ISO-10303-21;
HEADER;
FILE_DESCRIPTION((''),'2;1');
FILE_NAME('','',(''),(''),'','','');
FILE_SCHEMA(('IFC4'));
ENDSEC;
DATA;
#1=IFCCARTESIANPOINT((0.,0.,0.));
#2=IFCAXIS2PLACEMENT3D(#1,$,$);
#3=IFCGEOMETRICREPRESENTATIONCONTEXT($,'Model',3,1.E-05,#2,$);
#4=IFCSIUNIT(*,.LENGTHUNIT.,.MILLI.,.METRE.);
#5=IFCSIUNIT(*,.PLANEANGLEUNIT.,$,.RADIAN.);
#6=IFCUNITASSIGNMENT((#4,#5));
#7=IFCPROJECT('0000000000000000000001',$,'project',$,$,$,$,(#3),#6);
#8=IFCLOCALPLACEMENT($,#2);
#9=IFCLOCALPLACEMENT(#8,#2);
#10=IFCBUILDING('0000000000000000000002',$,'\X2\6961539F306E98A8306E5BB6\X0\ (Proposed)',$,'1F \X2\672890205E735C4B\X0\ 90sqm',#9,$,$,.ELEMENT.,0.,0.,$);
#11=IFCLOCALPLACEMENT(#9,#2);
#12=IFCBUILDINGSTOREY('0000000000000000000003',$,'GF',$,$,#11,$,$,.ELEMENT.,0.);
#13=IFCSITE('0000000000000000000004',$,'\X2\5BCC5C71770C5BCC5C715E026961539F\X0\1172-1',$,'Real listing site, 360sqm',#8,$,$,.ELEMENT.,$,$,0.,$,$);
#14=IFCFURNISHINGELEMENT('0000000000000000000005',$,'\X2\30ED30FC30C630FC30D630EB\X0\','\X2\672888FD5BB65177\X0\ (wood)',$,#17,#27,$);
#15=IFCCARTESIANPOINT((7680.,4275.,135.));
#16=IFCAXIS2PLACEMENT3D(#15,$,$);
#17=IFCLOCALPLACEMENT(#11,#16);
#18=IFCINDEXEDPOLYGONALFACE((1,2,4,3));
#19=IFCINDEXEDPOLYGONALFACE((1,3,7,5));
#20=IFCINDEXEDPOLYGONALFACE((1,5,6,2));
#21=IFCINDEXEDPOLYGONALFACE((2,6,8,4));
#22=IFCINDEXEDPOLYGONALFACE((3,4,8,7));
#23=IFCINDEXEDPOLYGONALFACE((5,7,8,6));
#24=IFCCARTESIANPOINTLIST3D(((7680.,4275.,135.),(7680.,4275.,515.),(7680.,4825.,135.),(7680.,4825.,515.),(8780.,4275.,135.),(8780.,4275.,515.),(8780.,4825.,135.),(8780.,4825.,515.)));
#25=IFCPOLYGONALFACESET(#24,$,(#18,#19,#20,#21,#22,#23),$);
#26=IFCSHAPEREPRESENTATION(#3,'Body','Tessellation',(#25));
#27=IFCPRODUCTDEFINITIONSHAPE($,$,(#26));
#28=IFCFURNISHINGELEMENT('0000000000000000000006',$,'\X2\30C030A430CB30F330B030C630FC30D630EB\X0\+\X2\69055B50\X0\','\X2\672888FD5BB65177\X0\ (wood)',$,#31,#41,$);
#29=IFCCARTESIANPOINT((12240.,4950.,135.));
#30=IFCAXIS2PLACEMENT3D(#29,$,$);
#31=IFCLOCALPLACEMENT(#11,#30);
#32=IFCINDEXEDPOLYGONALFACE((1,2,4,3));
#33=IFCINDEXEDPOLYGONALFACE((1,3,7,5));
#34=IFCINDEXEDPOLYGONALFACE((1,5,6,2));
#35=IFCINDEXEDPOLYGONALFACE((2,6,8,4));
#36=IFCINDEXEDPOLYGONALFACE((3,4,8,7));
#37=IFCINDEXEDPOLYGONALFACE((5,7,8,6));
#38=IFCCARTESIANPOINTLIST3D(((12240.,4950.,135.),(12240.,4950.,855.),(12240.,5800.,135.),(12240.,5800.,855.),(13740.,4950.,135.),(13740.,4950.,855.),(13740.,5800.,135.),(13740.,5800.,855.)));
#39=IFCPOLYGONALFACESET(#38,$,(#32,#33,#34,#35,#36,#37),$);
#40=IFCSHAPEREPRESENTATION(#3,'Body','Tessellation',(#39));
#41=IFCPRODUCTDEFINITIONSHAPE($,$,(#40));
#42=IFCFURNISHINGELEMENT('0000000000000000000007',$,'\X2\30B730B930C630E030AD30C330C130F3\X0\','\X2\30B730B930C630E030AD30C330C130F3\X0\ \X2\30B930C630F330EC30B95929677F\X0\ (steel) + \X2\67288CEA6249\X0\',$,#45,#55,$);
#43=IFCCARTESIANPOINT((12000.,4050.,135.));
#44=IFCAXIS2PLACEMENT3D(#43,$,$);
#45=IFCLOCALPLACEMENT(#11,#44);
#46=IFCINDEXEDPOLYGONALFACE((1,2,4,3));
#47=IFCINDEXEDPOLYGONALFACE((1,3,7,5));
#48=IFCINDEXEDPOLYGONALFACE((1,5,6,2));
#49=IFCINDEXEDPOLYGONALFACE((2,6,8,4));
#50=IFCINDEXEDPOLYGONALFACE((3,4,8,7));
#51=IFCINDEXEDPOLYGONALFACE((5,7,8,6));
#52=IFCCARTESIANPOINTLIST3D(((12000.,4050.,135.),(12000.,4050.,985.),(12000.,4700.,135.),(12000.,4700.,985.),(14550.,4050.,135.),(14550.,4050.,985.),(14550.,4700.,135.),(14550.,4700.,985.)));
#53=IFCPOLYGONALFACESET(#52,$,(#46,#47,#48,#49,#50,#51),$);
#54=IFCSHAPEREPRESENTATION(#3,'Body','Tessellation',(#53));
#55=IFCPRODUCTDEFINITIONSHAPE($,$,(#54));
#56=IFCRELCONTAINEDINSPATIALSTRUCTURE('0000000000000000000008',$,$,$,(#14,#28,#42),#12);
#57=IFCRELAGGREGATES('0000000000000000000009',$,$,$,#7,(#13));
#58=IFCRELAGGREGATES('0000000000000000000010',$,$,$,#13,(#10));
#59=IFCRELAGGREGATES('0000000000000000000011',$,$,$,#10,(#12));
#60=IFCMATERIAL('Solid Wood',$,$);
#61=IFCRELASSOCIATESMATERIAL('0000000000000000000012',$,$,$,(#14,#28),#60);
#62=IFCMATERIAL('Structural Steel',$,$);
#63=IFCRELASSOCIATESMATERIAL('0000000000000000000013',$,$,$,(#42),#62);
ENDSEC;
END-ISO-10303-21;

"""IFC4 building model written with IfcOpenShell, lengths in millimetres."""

from ifc_helpers import new_model, si_unit, frame, frame_2d, origin, place, context, project, spatial, rectangle, extrude, material, element, save


model = new_model("IFC4")

# Units and contexts
model_context = context("Model", 3, precision=1e-05, world=origin())
ifc_project = project(units=[si_unit("LENGTHUNIT", "METRE", prefix="MILLI"), si_unit("PLANEANGLEUNIT", "RADIAN")], contexts=[model_context])

# Site, building, storey
site_placement = place(None, origin())
site = spatial("IfcSite", under=ifc_project, at=site_placement, Name="富山県富山市楡原1172-1", ObjectType="Real listing site, 360sqm", CompositionType="ELEMENT", RefElevation=0.0)
building_placement = place(site_placement, origin())
building = spatial("IfcBuilding", under=site, at=building_placement, Name="楡原の風の家 (Proposed)", ObjectType="1F 木造平屋 90sqm", CompositionType="ELEMENT", ElevationOfRefHeight=0.0, ElevationOfTerrain=0.0)
storey_placement = place(building_placement, origin())
storey = spatial("IfcBuildingStorey", under=building, at=storey_placement, Name="GF", CompositionType="ELEMENT", Elevation=0.0)

# Shared definitions
ifc_material_1 = material(Name="Solid Wood")

# Shared definitions
ifc_material_2 = material(Name="Structural Steel")

# Furnishing elements
furnishing_1_placement = place(storey_placement, frame((7680.0, 4275.0, 135.0)))
element("IfcFurnishingElement", 1, at=furnishing_1_placement, inside=storey, material=ifc_material_1, Name="ローテーブル", Description="木製家具 (wood)", context=model_context, shape_type="SweptSolid", body=[
    extrude(rectangle(XDim=1100.0, YDim=550.0, at=frame_2d((550.0, 275.0))), frame((7680.0, 4275.0, 135.0)), (0.0, 0.0, 1.0), 380.0),
])
furnishing_2_placement = place(storey_placement, frame((12240.0, 4950.0, 135.0)))
element("IfcFurnishingElement", 2, at=furnishing_2_placement, inside=storey, material=ifc_material_1, Name="ダイニングテーブル+椅子", Description="木製家具 (wood)", context=model_context, shape_type="SweptSolid", body=[
    extrude(rectangle(XDim=1500.0, YDim=850.0, at=frame_2d((750.0, 425.0))), frame((12240.0, 4950.0, 135.0)), (0.0, 0.0, 1.0), 720.0),
])
furnishing_3_placement = place(storey_placement, frame((12000.0, 4050.0, 135.0)))
element("IfcFurnishingElement", 3, at=furnishing_3_placement, inside=storey, material=ifc_material_2, Name="システムキッチン", Description="システムキッチン ステンレス天板 (steel) + 木質扉", context=model_context, shape_type="SweptSolid", body=[
    extrude(rectangle(XDim=2550.0, YDim=650.0, at=frame_2d((1275.0, 325.0))), frame((12000.0, 4050.0, 135.0)), (0.0, 0.0, 1.0), 850.0),
])

save(model, "model.ifc")
